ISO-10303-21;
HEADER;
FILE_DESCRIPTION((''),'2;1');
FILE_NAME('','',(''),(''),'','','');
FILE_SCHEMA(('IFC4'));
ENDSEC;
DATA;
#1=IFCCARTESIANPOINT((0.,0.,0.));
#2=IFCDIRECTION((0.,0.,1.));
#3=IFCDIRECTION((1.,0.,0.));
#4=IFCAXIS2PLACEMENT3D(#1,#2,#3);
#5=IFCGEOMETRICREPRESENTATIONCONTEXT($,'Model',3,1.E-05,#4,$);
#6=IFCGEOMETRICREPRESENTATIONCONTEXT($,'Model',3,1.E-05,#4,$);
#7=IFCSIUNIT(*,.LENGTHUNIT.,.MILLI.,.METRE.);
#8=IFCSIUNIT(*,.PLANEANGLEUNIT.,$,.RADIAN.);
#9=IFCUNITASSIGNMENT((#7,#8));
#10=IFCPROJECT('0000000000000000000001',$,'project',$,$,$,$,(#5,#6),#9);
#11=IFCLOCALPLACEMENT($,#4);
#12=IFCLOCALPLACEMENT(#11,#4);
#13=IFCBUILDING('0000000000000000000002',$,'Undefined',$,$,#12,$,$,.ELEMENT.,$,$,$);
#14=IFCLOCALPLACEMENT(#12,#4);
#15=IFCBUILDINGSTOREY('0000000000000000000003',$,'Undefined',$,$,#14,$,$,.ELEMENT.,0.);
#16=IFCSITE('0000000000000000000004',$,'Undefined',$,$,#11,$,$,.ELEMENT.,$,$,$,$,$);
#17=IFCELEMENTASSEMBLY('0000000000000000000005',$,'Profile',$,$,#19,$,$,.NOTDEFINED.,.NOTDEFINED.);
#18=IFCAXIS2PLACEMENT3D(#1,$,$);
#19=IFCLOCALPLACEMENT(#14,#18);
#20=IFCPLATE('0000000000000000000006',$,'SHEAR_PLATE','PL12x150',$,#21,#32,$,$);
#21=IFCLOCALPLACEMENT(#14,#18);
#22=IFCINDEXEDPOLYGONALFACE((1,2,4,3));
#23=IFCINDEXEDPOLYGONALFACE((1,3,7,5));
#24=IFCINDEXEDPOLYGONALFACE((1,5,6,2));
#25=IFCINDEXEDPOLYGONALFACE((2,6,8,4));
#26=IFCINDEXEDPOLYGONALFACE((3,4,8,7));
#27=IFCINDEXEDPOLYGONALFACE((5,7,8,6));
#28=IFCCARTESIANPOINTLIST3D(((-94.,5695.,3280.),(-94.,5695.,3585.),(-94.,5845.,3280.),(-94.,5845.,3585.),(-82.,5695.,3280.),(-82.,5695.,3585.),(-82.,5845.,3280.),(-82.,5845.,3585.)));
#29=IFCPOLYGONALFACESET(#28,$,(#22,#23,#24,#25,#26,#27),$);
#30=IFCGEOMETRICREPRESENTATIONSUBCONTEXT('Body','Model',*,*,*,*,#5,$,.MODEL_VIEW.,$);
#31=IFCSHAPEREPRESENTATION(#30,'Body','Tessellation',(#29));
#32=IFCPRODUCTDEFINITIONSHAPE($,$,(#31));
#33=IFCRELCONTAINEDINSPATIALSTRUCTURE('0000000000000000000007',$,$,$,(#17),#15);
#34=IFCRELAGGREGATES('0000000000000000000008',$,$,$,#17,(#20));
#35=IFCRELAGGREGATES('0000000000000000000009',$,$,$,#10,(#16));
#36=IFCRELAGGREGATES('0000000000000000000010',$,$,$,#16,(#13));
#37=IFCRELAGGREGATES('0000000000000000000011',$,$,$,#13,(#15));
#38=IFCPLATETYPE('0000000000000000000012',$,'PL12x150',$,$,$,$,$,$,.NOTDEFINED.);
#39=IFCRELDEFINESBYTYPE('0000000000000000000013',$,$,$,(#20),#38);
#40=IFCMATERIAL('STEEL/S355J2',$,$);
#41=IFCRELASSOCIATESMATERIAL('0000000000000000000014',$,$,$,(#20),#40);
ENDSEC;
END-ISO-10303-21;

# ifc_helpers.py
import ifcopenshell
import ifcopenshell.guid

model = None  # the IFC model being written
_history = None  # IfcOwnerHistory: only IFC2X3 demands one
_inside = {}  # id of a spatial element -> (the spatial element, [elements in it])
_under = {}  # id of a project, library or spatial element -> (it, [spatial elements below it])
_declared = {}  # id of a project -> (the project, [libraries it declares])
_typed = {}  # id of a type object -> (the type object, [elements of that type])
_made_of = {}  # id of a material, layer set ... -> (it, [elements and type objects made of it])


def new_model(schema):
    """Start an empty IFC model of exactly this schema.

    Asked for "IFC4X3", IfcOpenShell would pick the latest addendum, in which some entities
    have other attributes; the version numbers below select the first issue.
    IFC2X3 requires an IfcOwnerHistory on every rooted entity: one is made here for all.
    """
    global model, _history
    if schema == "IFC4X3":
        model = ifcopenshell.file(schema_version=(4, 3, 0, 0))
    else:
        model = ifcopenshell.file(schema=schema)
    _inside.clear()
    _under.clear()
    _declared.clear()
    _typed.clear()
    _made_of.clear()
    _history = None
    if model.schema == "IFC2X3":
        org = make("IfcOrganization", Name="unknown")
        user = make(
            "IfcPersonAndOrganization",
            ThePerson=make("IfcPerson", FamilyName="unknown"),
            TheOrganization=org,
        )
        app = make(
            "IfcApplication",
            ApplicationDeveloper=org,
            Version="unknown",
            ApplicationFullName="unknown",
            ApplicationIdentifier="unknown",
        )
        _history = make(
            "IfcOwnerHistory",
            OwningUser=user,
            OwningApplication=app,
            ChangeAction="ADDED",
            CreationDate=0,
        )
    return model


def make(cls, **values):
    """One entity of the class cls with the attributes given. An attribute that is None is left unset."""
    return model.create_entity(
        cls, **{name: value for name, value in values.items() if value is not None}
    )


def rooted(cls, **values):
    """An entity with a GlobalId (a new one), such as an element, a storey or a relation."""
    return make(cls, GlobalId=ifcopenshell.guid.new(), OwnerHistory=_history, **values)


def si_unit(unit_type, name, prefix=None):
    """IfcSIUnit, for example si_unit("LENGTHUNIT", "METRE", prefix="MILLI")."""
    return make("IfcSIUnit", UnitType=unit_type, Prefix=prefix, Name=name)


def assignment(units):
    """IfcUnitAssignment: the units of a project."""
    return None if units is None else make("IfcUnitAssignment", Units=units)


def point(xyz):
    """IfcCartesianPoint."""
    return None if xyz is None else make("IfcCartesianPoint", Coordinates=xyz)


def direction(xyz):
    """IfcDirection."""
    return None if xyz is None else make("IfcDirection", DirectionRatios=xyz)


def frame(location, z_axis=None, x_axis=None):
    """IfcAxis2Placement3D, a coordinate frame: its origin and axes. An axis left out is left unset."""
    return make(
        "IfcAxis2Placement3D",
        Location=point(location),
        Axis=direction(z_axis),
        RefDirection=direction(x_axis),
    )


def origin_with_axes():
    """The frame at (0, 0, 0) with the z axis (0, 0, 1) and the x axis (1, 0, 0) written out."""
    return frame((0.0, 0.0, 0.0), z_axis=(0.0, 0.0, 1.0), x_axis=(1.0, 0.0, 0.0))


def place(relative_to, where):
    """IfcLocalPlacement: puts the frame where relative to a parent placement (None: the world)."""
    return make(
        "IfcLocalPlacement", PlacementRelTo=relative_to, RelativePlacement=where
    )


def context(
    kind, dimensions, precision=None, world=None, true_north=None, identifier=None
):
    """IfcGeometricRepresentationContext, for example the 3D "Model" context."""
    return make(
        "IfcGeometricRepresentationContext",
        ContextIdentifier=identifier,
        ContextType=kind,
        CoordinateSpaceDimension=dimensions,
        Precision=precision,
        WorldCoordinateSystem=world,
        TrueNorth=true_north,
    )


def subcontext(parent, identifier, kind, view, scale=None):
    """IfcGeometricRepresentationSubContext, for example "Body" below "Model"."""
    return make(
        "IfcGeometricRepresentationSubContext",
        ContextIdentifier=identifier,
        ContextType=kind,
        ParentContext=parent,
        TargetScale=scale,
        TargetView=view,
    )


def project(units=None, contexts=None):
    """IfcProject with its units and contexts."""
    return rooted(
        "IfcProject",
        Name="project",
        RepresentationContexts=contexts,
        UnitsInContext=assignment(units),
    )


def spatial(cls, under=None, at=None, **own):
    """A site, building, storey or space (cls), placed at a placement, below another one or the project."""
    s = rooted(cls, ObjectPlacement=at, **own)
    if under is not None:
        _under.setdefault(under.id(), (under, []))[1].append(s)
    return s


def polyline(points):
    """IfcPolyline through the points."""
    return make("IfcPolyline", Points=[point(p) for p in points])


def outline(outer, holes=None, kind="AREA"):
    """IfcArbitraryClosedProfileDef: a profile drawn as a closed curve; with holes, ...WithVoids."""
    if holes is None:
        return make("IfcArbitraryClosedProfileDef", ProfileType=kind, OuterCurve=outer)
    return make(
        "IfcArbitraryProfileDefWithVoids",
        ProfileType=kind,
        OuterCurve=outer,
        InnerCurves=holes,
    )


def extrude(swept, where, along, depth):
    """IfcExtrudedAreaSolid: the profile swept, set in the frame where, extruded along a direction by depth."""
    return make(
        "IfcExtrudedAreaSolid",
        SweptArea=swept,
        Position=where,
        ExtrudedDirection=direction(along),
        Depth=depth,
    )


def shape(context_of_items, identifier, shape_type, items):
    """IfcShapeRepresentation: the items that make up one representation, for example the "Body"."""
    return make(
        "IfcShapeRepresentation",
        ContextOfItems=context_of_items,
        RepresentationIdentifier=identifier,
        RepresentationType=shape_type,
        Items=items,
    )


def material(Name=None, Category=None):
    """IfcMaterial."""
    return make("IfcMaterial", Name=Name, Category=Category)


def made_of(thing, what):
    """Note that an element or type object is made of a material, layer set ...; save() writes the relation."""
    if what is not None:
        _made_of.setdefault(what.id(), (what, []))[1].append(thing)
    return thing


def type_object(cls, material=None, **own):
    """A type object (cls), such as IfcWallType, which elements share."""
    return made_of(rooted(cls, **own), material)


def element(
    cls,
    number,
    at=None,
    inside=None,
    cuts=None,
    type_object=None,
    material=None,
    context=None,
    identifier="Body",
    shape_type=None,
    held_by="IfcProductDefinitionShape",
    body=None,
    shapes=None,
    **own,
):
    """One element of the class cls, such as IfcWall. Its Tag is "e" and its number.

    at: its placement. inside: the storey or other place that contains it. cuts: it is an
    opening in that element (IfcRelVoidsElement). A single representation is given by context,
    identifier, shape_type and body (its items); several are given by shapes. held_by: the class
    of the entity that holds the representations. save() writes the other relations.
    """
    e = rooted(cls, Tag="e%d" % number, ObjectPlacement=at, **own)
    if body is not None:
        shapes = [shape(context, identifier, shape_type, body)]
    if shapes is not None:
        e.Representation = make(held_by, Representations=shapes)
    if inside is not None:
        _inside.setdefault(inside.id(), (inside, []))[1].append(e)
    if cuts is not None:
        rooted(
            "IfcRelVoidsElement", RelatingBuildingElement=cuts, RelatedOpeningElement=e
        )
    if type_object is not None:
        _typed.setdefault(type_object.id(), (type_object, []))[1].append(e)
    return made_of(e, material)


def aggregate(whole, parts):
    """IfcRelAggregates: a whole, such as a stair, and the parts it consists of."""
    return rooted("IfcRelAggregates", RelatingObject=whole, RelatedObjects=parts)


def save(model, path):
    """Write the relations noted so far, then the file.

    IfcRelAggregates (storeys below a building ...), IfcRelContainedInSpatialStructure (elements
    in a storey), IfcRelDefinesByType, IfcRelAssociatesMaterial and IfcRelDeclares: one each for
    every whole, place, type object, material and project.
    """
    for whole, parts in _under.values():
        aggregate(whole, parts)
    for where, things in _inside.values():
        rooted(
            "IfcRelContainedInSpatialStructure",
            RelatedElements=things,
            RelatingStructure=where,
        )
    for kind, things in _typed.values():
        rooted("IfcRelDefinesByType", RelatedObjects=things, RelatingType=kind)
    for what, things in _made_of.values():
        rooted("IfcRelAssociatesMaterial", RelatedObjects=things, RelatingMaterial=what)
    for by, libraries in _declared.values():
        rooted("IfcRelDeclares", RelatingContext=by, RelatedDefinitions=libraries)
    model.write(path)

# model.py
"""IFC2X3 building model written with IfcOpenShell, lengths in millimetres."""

from ifc_helpers import new_model, si_unit, frame, origin_with_axes, place, context, subcontext, project, spatial, polyline, outline, extrude, material, type_object, element, aggregate, save


model = new_model("IFC2X3")

# Units and contexts
model_context_1 = context("Model", 3, precision=1e-05, world=origin_with_axes())
model_context_2 = context("Model", 3, precision=1e-05, world=origin_with_axes())
body_context = subcontext(model_context_1, "Body", "Model", "MODEL_VIEW")
ifc_project = project(units=[si_unit("LENGTHUNIT", "METRE", prefix="MILLI"), si_unit("PLANEANGLEUNIT", "RADIAN")], contexts=[model_context_1, model_context_2])

# Site, building, storey
site_placement = place(None, origin_with_axes())
site = spatial("IfcSite", under=ifc_project, at=site_placement, Name="Undefined", CompositionType="ELEMENT")
building_placement = place(site_placement, origin_with_axes())
building = spatial("IfcBuilding", under=site, at=building_placement, Name="Undefined", CompositionType="ELEMENT")
storey_placement = place(building_placement, origin_with_axes())
storey = spatial("IfcBuildingStorey", under=building, at=storey_placement, Name="Undefined", CompositionType="ELEMENT", Elevation=0.0)

# Element assembly
assembly_1_placement = place(storey_placement, origin_with_axes())
assembly_1 = element("IfcElementAssembly", 1, at=assembly_1_placement, inside=storey, Name="Profile", AssemblyPlace="NOTDEFINED", PredefinedType="NOTDEFINED")
ifc_material_1 = material(Name="STEEL/S355J2")

# Shared definitions
plate_type_1 = type_object("IfcPlateType", Name="PL12x150", PredefinedType="NOTDEFINED")

# Plate
plate_1_placement = place(assembly_1_placement, frame((-88.0, 5845.0, 3585.0), z_axis=(1.0, 0.0, 0.0), x_axis=(0.0, -1.0, 0.0)))
plate_1 = element("IfcPlate", 2, at=plate_1_placement, type_object=plate_type_1, material=ifc_material_1, Name="SHEAR_PLATE", Description="PL12x150", context=body_context, shape_type="SweptSolid", body=[
    extrude(outline(polyline([(0.0, 0.0), (150.0, 0.0), (150.0, 0.0), (150.0, 305.0), (150.0, 305.0), (0.0, 305.0), (0.0, 305.0), (0.0, 0.0)])), frame((0.0, 0.0, -6.0), z_axis=(0.0, 0.0, 1.0), x_axis=(1.0, 0.0, 0.0)), (0.0, 0.0, 1.0), 12.0),
])
aggregate(assembly_1, [plate_1])

save(model, "model.ifc")
